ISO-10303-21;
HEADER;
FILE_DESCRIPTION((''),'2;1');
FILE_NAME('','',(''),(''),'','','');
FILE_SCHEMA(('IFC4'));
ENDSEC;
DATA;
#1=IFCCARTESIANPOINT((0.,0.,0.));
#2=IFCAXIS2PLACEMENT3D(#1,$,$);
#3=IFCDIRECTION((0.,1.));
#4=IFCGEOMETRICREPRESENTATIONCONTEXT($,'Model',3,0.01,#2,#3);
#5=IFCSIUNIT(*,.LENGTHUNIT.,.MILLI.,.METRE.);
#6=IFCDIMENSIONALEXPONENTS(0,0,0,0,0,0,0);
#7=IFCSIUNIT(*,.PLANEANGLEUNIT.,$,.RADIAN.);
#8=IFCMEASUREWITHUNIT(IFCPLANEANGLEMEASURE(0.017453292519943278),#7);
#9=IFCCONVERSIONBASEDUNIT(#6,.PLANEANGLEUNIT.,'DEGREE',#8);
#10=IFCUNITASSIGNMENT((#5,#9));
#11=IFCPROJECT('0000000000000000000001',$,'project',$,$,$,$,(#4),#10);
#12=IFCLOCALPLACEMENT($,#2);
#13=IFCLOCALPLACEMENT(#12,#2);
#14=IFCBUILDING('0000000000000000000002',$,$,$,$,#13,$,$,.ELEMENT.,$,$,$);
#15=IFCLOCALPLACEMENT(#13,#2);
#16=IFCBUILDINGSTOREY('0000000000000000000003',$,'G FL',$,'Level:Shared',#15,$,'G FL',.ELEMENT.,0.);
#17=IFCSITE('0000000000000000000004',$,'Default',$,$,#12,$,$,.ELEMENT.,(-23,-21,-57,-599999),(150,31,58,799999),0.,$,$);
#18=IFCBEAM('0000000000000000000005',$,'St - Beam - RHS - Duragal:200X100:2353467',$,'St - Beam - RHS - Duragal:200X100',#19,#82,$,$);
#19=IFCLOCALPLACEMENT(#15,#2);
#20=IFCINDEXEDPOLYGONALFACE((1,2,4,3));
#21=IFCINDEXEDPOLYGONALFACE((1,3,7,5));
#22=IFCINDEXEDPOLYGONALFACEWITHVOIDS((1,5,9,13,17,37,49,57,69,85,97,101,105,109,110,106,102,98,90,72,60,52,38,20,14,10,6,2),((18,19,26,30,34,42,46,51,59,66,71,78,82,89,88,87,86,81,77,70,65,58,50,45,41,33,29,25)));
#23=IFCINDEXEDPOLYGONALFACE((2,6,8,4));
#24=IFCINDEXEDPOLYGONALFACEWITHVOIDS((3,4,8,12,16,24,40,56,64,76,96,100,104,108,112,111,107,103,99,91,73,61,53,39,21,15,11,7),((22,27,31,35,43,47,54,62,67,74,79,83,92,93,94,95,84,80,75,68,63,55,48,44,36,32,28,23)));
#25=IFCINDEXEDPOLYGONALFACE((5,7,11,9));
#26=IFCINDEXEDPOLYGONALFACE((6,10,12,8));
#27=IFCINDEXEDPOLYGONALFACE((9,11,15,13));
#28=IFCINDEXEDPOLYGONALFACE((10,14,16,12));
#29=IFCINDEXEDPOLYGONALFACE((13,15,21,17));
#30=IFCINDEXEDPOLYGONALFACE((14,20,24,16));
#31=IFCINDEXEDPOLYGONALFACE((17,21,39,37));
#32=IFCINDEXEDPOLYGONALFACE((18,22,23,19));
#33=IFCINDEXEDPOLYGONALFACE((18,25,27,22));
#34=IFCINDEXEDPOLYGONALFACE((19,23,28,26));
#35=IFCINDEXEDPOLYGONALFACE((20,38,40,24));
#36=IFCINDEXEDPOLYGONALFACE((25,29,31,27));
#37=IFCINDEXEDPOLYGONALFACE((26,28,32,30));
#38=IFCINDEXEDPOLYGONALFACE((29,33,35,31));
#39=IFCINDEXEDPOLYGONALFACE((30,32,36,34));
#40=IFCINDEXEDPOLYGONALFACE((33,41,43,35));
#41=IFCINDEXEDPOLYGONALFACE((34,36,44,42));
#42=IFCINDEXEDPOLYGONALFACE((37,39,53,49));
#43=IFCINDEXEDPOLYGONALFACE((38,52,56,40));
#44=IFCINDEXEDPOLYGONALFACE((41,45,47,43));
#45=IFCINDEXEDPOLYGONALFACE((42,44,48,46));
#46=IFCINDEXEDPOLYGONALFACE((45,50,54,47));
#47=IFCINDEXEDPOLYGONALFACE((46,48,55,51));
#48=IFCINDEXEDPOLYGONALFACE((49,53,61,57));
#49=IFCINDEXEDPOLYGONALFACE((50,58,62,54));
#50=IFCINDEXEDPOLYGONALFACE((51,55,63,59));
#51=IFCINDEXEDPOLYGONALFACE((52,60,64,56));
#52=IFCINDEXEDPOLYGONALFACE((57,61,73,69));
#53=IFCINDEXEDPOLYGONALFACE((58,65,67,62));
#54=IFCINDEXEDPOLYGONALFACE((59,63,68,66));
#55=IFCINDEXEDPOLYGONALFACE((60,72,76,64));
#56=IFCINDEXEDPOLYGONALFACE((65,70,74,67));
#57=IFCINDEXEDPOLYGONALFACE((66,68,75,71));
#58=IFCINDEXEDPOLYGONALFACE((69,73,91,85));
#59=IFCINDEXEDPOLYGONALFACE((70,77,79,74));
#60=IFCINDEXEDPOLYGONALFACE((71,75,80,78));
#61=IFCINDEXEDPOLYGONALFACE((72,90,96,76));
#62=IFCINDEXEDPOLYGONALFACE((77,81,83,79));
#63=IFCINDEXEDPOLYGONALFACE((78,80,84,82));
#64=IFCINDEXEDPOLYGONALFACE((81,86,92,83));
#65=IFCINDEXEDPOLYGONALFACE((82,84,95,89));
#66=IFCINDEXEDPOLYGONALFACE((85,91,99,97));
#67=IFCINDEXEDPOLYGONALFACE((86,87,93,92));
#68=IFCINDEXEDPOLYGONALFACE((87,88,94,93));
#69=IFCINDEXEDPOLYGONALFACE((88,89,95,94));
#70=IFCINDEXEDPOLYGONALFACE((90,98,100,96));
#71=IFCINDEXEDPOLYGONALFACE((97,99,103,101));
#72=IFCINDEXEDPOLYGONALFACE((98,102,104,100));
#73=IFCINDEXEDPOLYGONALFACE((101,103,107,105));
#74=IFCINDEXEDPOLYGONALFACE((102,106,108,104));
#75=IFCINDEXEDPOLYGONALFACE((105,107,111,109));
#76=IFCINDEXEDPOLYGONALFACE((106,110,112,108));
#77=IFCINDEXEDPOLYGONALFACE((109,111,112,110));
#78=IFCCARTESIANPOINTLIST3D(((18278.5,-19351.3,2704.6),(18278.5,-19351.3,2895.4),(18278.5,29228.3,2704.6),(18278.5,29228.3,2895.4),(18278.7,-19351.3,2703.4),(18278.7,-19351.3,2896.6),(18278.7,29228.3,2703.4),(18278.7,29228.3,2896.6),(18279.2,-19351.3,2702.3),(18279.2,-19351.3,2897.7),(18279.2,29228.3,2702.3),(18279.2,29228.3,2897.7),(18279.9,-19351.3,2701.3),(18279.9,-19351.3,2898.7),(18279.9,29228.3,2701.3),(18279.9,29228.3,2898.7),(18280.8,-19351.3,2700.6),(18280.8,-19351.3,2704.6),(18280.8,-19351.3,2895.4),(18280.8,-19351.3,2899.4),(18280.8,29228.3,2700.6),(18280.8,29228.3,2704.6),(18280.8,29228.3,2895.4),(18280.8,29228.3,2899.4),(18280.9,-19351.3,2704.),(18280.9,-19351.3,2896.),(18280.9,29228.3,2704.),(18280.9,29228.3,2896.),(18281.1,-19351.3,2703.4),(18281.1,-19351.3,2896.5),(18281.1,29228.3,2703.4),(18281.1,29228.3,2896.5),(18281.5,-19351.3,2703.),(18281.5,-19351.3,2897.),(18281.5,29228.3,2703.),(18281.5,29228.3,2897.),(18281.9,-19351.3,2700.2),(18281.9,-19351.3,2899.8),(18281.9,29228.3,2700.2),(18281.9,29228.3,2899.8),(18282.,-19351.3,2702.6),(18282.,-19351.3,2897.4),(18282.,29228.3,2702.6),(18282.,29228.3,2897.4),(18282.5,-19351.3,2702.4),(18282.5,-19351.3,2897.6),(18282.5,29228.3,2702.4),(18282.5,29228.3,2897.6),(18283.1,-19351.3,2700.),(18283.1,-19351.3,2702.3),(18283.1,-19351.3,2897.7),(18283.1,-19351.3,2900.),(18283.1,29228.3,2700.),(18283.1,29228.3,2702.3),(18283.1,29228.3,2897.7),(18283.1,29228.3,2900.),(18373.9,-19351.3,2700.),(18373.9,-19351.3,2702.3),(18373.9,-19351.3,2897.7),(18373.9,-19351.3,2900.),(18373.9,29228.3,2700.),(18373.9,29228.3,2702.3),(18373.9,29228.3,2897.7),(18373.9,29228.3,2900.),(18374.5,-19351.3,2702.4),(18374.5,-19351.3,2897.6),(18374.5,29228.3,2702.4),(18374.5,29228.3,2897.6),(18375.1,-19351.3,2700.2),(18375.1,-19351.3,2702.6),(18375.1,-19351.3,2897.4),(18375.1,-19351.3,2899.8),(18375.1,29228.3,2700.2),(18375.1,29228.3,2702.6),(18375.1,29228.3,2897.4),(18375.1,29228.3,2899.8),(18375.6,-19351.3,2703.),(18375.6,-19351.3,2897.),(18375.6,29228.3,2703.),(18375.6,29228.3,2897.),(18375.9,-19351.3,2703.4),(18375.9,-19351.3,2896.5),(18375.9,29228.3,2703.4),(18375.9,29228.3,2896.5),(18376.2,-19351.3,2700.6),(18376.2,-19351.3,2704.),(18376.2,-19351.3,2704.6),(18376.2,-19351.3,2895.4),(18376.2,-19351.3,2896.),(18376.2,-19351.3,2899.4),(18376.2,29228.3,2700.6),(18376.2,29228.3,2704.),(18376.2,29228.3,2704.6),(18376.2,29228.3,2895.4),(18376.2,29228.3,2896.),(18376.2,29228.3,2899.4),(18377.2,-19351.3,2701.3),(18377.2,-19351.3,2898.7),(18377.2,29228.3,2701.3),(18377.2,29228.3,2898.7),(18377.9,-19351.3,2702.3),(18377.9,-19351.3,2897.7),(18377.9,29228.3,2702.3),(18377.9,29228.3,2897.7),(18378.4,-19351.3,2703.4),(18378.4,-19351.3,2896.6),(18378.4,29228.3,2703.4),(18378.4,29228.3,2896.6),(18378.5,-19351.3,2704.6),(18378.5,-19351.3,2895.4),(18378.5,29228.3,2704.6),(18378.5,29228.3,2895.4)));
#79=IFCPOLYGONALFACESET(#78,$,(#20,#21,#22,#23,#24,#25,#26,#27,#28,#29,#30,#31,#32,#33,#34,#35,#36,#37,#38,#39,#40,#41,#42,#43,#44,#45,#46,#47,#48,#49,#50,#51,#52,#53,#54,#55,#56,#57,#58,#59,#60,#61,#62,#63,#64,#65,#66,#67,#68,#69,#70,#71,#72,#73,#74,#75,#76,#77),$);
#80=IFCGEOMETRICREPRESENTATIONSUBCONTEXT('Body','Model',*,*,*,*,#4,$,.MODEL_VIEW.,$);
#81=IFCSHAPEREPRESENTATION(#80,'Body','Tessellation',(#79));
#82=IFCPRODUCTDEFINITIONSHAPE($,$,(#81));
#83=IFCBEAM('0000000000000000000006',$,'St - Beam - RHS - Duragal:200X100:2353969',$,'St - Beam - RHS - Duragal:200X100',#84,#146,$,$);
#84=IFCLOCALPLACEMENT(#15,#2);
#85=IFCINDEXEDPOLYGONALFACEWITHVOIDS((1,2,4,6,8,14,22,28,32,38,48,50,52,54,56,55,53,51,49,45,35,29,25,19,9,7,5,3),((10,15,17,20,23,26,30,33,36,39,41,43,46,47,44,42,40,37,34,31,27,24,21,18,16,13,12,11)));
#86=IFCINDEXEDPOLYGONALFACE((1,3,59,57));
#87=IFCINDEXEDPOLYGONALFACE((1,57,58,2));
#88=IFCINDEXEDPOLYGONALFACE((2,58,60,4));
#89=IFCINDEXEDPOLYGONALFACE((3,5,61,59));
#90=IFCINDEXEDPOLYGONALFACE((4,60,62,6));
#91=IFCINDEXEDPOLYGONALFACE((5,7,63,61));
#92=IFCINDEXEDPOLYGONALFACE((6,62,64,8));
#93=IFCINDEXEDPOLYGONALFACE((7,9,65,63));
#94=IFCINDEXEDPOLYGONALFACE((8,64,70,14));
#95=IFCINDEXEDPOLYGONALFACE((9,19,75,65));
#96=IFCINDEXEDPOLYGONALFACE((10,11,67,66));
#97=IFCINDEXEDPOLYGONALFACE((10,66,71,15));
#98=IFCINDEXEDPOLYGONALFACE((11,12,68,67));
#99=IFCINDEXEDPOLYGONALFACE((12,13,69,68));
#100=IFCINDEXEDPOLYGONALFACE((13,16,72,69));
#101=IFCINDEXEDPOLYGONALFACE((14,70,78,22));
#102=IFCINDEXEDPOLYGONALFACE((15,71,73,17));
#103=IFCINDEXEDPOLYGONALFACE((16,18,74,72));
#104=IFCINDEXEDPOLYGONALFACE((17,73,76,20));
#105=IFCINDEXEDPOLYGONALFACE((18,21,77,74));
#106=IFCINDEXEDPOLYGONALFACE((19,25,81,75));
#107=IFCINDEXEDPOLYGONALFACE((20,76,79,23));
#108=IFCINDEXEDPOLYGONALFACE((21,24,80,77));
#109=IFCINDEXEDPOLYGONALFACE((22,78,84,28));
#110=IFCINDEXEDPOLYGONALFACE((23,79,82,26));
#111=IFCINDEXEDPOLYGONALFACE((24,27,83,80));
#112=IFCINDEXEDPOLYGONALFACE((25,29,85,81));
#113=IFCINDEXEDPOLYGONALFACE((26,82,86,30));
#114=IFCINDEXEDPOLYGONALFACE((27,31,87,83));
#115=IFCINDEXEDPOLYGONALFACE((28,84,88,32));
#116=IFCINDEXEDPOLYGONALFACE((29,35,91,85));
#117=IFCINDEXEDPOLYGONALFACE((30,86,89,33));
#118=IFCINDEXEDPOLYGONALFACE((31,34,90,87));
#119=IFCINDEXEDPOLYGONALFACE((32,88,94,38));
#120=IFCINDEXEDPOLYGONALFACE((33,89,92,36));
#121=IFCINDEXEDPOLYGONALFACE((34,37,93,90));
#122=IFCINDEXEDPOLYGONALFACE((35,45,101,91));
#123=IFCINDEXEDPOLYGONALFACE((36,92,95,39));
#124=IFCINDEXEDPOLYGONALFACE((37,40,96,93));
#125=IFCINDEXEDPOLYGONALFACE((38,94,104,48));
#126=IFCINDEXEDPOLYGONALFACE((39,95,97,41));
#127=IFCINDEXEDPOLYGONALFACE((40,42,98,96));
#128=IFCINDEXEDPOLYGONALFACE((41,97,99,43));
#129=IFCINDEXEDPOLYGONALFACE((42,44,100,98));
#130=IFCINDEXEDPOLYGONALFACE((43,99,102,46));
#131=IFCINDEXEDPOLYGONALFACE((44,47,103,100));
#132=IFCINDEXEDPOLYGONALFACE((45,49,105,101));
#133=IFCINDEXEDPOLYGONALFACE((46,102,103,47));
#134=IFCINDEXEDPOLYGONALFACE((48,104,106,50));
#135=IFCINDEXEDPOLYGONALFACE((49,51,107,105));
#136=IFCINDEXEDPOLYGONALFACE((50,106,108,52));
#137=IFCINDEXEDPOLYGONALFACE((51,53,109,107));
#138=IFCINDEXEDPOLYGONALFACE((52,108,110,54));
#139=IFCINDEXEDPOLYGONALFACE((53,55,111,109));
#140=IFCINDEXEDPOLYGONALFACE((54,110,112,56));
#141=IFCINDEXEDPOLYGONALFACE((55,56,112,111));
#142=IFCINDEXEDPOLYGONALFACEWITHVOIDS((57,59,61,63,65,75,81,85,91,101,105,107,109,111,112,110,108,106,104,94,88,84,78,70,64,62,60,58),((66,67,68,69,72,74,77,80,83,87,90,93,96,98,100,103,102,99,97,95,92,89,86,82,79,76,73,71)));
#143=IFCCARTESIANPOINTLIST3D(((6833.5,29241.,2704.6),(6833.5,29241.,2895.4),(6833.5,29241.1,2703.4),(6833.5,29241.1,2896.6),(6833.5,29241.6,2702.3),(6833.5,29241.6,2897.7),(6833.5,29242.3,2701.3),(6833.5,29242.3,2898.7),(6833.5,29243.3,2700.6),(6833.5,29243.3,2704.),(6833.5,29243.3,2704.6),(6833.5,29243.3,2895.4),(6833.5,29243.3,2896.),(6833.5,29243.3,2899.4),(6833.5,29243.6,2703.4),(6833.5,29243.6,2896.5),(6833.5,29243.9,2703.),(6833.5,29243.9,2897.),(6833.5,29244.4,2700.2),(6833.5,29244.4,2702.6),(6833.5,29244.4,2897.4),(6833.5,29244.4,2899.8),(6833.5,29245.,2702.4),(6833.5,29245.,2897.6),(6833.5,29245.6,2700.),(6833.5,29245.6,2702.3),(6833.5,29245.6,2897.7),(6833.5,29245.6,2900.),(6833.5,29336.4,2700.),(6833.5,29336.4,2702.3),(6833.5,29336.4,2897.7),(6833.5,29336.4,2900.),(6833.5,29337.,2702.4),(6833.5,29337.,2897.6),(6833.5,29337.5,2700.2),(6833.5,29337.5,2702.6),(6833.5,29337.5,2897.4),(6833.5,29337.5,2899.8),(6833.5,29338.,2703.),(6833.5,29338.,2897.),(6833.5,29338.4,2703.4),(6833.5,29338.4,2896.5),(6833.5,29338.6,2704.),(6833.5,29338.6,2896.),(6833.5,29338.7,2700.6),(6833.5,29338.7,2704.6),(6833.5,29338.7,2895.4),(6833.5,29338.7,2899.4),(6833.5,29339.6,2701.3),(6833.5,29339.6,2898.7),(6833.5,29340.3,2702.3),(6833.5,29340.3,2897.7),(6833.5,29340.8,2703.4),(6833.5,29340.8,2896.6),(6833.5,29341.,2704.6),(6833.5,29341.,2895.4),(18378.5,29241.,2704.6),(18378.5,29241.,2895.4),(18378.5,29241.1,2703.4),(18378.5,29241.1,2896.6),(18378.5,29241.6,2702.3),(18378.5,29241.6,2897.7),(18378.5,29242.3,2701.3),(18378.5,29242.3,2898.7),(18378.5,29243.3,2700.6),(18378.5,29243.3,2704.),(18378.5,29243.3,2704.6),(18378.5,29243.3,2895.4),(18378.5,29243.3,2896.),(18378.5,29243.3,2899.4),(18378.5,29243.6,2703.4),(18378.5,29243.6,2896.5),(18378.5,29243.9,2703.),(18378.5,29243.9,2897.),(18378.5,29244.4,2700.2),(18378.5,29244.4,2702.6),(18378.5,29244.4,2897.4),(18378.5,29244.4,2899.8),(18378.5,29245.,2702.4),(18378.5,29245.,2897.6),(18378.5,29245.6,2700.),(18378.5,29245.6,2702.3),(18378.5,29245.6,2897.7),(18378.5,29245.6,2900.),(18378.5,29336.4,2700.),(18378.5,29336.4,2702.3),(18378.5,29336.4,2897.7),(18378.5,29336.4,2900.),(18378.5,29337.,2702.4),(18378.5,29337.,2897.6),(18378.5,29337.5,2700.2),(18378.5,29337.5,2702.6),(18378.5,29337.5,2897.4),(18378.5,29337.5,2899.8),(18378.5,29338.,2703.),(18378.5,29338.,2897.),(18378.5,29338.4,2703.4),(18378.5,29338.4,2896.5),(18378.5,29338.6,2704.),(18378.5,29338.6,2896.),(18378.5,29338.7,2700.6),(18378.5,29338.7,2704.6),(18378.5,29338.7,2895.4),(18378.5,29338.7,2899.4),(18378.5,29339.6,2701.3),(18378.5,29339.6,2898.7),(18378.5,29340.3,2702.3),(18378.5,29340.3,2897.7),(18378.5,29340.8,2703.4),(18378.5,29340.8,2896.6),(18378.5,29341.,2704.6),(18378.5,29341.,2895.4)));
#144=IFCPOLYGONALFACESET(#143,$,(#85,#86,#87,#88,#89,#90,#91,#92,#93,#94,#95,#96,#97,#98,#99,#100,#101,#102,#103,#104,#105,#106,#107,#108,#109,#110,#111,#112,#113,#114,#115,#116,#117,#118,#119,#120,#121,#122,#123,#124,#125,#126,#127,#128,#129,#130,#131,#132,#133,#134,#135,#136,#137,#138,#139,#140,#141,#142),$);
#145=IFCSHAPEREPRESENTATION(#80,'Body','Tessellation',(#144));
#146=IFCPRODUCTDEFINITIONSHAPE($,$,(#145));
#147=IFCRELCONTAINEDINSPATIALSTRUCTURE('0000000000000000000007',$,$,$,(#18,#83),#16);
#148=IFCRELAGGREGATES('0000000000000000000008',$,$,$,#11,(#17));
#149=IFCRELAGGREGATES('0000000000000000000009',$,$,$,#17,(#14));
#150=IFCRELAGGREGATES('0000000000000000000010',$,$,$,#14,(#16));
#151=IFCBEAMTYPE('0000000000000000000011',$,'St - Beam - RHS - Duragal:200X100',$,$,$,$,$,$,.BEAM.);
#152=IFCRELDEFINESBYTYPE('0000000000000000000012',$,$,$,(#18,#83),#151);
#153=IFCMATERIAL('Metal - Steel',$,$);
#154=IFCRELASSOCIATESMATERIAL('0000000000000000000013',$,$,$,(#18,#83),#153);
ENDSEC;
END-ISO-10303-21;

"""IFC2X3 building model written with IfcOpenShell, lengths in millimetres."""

from ifc_helpers import new_model, entity, si_unit, converted_unit, direction, frame, frame_2d, origin, place, context, subcontext, project, spatial, polyline, circle_curve, parameter, trimmed, segment, composite_curve, outline, extrude, material, type_object, element, save


model = new_model("IFC2X3")

# Units and contexts
model_context = context("Model", 3, precision=0.01, world=origin(), true_north=direction((0.0, 1.0)))
body_context = subcontext(model_context, "Body", "Model", "MODEL_VIEW")
ifc_project = project(units=[si_unit("LENGTHUNIT", "METRE", prefix="MILLI"), converted_unit("PLANEANGLEUNIT", "DEGREE", entity("IfcPlaneAngleMeasure", 0.017453292519943278), si_unit("PLANEANGLEUNIT", "RADIAN"), dimensions=[0, 0, 0, 0, 0, 0, 0])], contexts=[model_context])

# Site, building, storey
site_placement = place(None, origin())
site = spatial("IfcSite", under=ifc_project, at=site_placement, Name="Default", CompositionType="ELEMENT", RefLatitude=(-23, -21, -57, -599999), RefLongitude=(150, 31, 58, 799999), RefElevation=0.0)
building_placement = place(site_placement, origin())
building = spatial("IfcBuilding", under=site, at=building_placement, CompositionType="ELEMENT")
storey_placement = place(building_placement, origin())
storey = spatial("IfcBuildingStorey", under=building, at=storey_placement, Name="G FL", ObjectType="Level:Shared", LongName="G FL", CompositionType="ELEMENT", Elevation=0.0)

# Beams
ifc_material_1 = material(Name="Metal - Steel")
beam_type_1 = type_object("IfcBeamType", Name="St - Beam - RHS - Duragal:200X100", PredefinedType="BEAM")
beam_1_placement = place(storey_placement, frame((18328.5, 29291.0, 2900.0), z_axis=(0.0, 0.0, 1.0), x_axis=(0.0, -1.0, 0.0)))
element("IfcBeam", 1, at=beam_1_placement, inside=storey, type_object=beam_type_1, material=ifc_material_1, Name="St - Beam - RHS - Duragal:200X100:2353467", ObjectType="St - Beam - RHS - Duragal:200X100", context=body_context, shape_type="SweptSolid", body=[
    extrude(outline(composite_curve([segment(trimmed(circle_curve(frame_2d((-45.4, 95.4), x_axis=(1.0, 0.0)), 4.6), [parameter(90.0)], [parameter(180.0)], True, "PARAMETER"), True, "CONTINUOUS"), segment(polyline([(-50.0, 95.4), (-50.0, -95.4)]), True, "CONTINUOUS"), segment(trimmed(circle_curve(frame_2d((-45.4, -95.4), x_axis=(1.0, 0.0)), 4.6), [parameter(180.0)], [parameter(270.0)], True, "PARAMETER"), True, "CONTINUOUS"), segment(polyline([(-45.4, -100.0), (45.4, -100.0)]), True, "CONTINUOUS"), segment(trimmed(circle_curve(frame_2d((45.4, -95.4), x_axis=(1.0, 0.0)), 4.6), [parameter(270.0)], [parameter(0.0)], True, "PARAMETER"), True, "CONTINUOUS"), segment(polyline([(50.0, -95.4), (50.0, 95.4)]), True, "CONTINUOUS"), segment(trimmed(circle_curve(frame_2d((45.4, 95.4), x_axis=(1.0, 0.0)), 4.6), [parameter(0.0)], [parameter(90.0)], True, "PARAMETER"), True, "CONTINUOUS"), segment(polyline([(45.4, 100.0), (-45.4, 100.0)]), True, "CONTINUOUS")], self_intersect=False), holes=[composite_curve([segment(trimmed(circle_curve(frame_2d((45.4, -95.4), x_axis=(1.0, 0.0)), 2.3), [parameter(270.0)], [parameter(0.0)], True, "PARAMETER"), False, "CONTINUOUS"), segment(polyline([(45.4, -97.7), (-45.4, -97.7)]), True, "CONTINUOUS"), segment(trimmed(circle_curve(frame_2d((-45.4, -95.4), x_axis=(1.0, 0.0)), 2.3), [parameter(180.0)], [parameter(270.0)], True, "PARAMETER"), False, "CONTINUOUS"), segment(polyline([(-47.7, -95.4), (-47.7, 95.4)]), True, "CONTINUOUS"), segment(trimmed(circle_curve(frame_2d((-45.4, 95.4), x_axis=(1.0, 0.0)), 2.3), [parameter(90.0)], [parameter(180.0)], True, "PARAMETER"), False, "CONTINUOUS"), segment(polyline([(-45.4, 97.7), (45.4, 97.7)]), True, "CONTINUOUS"), segment(trimmed(circle_curve(frame_2d((45.4, 95.4), x_axis=(1.0, 0.0)), 2.3), [parameter(0.0)], [parameter(90.0)], True, "PARAMETER"), False, "CONTINUOUS"), segment(polyline([(47.7, 95.4), (47.7, -95.4)]), True, "CONTINUOUS")], self_intersect=False)]), frame((62.7, 0.0, -100.0), z_axis=(1.0, 0.0, 0.0), x_axis=(0.0, 1.0, 0.0)), (0.0, 0.0, 1.0), 48579.6),
])
beam_2_placement = place(storey_placement, frame((18328.5, 29291.0, 2900.0), z_axis=(0.0, 0.0, 1.0), x_axis=(-1.0, 0.0, 0.0)))
element("IfcBeam", 2, at=beam_2_placement, inside=storey, type_object=beam_type_1, material=ifc_material_1, Name="St - Beam - RHS - Duragal:200X100:2353969", ObjectType="St - Beam - RHS - Duragal:200X100", context=body_context, shape_type="SweptSolid", body=[
    extrude(outline(composite_curve([segment(polyline([(-45.4, -100.0), (45.4, -100.0)]), True, "CONTINUOUS"), segment(trimmed(circle_curve(frame_2d((45.4, -95.4), x_axis=(0.0, -1.0)), 4.6), [parameter(0.0)], [parameter(90.0)], True, "PARAMETER"), True, "CONTINUOUS"), segment(polyline([(50.0, -95.4), (50.0, 95.4)]), True, "CONTINUOUS"), segment(trimmed(circle_curve(frame_2d((45.4, 95.4), x_axis=(1.0, 0.0)), 4.6), [parameter(360.0)], [parameter(90.0)], True, "PARAMETER"), True, "CONTINUOUS"), segment(polyline([(45.4, 100.0), (-45.4, 100.0)]), True, "CONTINUOUS"), segment(trimmed(circle_curve(frame_2d((-45.4, 95.4), x_axis=(0.0, 1.0)), 4.6), [parameter(360.0)], [parameter(90.0)], True, "PARAMETER"), True, "CONTINUOUS"), segment(polyline([(-50.0, 95.4), (-50.0, -95.4)]), True, "CONTINUOUS"), segment(trimmed(circle_curve(frame_2d((-45.4, -95.4), x_axis=(-1.0, 0.0)), 4.6), [parameter(360.0)], [parameter(90.0)], True, "PARAMETER"), True, "CONTINUOUS")], self_intersect=False), holes=[composite_curve([segment(polyline([(47.7, 95.4), (47.7, -95.4)]), True, "CONTINUOUS"), segment(trimmed(circle_curve(frame_2d((45.4, -95.4), x_axis=(1.0, 0.0)), 2.3), [parameter(270.0)], [parameter(0.0)], True, "PARAMETER"), False, "CONTINUOUS"), segment(polyline([(45.4, -97.7), (-45.4, -97.7)]), True, "CONTINUOUS"), segment(trimmed(circle_curve(frame_2d((-45.4, -95.4), x_axis=(0.0, -1.0)), 2.3), [parameter(270.0)], [parameter(360.0)], True, "PARAMETER"), False, "CONTINUOUS"), segment(polyline([(-47.7, -95.4), (-47.7, 95.4)]), True, "CONTINUOUS"), segment(trimmed(circle_curve(frame_2d((-45.4, 95.4), x_axis=(-1.0, 0.0)), 2.3), [parameter(270.0)], [parameter(0.0)], True, "PARAMETER"), False, "CONTINUOUS"), segment(polyline([(-45.4, 97.7), (45.4, 97.7)]), True, "CONTINUOUS"), segment(trimmed(circle_curve(frame_2d((45.4, 95.4), x_axis=(0.0, 1.0)), 2.3), [parameter(270.0)], [parameter(0.0)], True, "PARAMETER"), False, "CONTINUOUS")], self_intersect=False)]), frame((-50.0, 0.0, -100.0), z_axis=(1.0, 0.0, 0.0), x_axis=(0.0, -1.0, 0.0)), (0.0, 0.0, 1.0), 11545.0),
])

save(model, "model.ifc")
